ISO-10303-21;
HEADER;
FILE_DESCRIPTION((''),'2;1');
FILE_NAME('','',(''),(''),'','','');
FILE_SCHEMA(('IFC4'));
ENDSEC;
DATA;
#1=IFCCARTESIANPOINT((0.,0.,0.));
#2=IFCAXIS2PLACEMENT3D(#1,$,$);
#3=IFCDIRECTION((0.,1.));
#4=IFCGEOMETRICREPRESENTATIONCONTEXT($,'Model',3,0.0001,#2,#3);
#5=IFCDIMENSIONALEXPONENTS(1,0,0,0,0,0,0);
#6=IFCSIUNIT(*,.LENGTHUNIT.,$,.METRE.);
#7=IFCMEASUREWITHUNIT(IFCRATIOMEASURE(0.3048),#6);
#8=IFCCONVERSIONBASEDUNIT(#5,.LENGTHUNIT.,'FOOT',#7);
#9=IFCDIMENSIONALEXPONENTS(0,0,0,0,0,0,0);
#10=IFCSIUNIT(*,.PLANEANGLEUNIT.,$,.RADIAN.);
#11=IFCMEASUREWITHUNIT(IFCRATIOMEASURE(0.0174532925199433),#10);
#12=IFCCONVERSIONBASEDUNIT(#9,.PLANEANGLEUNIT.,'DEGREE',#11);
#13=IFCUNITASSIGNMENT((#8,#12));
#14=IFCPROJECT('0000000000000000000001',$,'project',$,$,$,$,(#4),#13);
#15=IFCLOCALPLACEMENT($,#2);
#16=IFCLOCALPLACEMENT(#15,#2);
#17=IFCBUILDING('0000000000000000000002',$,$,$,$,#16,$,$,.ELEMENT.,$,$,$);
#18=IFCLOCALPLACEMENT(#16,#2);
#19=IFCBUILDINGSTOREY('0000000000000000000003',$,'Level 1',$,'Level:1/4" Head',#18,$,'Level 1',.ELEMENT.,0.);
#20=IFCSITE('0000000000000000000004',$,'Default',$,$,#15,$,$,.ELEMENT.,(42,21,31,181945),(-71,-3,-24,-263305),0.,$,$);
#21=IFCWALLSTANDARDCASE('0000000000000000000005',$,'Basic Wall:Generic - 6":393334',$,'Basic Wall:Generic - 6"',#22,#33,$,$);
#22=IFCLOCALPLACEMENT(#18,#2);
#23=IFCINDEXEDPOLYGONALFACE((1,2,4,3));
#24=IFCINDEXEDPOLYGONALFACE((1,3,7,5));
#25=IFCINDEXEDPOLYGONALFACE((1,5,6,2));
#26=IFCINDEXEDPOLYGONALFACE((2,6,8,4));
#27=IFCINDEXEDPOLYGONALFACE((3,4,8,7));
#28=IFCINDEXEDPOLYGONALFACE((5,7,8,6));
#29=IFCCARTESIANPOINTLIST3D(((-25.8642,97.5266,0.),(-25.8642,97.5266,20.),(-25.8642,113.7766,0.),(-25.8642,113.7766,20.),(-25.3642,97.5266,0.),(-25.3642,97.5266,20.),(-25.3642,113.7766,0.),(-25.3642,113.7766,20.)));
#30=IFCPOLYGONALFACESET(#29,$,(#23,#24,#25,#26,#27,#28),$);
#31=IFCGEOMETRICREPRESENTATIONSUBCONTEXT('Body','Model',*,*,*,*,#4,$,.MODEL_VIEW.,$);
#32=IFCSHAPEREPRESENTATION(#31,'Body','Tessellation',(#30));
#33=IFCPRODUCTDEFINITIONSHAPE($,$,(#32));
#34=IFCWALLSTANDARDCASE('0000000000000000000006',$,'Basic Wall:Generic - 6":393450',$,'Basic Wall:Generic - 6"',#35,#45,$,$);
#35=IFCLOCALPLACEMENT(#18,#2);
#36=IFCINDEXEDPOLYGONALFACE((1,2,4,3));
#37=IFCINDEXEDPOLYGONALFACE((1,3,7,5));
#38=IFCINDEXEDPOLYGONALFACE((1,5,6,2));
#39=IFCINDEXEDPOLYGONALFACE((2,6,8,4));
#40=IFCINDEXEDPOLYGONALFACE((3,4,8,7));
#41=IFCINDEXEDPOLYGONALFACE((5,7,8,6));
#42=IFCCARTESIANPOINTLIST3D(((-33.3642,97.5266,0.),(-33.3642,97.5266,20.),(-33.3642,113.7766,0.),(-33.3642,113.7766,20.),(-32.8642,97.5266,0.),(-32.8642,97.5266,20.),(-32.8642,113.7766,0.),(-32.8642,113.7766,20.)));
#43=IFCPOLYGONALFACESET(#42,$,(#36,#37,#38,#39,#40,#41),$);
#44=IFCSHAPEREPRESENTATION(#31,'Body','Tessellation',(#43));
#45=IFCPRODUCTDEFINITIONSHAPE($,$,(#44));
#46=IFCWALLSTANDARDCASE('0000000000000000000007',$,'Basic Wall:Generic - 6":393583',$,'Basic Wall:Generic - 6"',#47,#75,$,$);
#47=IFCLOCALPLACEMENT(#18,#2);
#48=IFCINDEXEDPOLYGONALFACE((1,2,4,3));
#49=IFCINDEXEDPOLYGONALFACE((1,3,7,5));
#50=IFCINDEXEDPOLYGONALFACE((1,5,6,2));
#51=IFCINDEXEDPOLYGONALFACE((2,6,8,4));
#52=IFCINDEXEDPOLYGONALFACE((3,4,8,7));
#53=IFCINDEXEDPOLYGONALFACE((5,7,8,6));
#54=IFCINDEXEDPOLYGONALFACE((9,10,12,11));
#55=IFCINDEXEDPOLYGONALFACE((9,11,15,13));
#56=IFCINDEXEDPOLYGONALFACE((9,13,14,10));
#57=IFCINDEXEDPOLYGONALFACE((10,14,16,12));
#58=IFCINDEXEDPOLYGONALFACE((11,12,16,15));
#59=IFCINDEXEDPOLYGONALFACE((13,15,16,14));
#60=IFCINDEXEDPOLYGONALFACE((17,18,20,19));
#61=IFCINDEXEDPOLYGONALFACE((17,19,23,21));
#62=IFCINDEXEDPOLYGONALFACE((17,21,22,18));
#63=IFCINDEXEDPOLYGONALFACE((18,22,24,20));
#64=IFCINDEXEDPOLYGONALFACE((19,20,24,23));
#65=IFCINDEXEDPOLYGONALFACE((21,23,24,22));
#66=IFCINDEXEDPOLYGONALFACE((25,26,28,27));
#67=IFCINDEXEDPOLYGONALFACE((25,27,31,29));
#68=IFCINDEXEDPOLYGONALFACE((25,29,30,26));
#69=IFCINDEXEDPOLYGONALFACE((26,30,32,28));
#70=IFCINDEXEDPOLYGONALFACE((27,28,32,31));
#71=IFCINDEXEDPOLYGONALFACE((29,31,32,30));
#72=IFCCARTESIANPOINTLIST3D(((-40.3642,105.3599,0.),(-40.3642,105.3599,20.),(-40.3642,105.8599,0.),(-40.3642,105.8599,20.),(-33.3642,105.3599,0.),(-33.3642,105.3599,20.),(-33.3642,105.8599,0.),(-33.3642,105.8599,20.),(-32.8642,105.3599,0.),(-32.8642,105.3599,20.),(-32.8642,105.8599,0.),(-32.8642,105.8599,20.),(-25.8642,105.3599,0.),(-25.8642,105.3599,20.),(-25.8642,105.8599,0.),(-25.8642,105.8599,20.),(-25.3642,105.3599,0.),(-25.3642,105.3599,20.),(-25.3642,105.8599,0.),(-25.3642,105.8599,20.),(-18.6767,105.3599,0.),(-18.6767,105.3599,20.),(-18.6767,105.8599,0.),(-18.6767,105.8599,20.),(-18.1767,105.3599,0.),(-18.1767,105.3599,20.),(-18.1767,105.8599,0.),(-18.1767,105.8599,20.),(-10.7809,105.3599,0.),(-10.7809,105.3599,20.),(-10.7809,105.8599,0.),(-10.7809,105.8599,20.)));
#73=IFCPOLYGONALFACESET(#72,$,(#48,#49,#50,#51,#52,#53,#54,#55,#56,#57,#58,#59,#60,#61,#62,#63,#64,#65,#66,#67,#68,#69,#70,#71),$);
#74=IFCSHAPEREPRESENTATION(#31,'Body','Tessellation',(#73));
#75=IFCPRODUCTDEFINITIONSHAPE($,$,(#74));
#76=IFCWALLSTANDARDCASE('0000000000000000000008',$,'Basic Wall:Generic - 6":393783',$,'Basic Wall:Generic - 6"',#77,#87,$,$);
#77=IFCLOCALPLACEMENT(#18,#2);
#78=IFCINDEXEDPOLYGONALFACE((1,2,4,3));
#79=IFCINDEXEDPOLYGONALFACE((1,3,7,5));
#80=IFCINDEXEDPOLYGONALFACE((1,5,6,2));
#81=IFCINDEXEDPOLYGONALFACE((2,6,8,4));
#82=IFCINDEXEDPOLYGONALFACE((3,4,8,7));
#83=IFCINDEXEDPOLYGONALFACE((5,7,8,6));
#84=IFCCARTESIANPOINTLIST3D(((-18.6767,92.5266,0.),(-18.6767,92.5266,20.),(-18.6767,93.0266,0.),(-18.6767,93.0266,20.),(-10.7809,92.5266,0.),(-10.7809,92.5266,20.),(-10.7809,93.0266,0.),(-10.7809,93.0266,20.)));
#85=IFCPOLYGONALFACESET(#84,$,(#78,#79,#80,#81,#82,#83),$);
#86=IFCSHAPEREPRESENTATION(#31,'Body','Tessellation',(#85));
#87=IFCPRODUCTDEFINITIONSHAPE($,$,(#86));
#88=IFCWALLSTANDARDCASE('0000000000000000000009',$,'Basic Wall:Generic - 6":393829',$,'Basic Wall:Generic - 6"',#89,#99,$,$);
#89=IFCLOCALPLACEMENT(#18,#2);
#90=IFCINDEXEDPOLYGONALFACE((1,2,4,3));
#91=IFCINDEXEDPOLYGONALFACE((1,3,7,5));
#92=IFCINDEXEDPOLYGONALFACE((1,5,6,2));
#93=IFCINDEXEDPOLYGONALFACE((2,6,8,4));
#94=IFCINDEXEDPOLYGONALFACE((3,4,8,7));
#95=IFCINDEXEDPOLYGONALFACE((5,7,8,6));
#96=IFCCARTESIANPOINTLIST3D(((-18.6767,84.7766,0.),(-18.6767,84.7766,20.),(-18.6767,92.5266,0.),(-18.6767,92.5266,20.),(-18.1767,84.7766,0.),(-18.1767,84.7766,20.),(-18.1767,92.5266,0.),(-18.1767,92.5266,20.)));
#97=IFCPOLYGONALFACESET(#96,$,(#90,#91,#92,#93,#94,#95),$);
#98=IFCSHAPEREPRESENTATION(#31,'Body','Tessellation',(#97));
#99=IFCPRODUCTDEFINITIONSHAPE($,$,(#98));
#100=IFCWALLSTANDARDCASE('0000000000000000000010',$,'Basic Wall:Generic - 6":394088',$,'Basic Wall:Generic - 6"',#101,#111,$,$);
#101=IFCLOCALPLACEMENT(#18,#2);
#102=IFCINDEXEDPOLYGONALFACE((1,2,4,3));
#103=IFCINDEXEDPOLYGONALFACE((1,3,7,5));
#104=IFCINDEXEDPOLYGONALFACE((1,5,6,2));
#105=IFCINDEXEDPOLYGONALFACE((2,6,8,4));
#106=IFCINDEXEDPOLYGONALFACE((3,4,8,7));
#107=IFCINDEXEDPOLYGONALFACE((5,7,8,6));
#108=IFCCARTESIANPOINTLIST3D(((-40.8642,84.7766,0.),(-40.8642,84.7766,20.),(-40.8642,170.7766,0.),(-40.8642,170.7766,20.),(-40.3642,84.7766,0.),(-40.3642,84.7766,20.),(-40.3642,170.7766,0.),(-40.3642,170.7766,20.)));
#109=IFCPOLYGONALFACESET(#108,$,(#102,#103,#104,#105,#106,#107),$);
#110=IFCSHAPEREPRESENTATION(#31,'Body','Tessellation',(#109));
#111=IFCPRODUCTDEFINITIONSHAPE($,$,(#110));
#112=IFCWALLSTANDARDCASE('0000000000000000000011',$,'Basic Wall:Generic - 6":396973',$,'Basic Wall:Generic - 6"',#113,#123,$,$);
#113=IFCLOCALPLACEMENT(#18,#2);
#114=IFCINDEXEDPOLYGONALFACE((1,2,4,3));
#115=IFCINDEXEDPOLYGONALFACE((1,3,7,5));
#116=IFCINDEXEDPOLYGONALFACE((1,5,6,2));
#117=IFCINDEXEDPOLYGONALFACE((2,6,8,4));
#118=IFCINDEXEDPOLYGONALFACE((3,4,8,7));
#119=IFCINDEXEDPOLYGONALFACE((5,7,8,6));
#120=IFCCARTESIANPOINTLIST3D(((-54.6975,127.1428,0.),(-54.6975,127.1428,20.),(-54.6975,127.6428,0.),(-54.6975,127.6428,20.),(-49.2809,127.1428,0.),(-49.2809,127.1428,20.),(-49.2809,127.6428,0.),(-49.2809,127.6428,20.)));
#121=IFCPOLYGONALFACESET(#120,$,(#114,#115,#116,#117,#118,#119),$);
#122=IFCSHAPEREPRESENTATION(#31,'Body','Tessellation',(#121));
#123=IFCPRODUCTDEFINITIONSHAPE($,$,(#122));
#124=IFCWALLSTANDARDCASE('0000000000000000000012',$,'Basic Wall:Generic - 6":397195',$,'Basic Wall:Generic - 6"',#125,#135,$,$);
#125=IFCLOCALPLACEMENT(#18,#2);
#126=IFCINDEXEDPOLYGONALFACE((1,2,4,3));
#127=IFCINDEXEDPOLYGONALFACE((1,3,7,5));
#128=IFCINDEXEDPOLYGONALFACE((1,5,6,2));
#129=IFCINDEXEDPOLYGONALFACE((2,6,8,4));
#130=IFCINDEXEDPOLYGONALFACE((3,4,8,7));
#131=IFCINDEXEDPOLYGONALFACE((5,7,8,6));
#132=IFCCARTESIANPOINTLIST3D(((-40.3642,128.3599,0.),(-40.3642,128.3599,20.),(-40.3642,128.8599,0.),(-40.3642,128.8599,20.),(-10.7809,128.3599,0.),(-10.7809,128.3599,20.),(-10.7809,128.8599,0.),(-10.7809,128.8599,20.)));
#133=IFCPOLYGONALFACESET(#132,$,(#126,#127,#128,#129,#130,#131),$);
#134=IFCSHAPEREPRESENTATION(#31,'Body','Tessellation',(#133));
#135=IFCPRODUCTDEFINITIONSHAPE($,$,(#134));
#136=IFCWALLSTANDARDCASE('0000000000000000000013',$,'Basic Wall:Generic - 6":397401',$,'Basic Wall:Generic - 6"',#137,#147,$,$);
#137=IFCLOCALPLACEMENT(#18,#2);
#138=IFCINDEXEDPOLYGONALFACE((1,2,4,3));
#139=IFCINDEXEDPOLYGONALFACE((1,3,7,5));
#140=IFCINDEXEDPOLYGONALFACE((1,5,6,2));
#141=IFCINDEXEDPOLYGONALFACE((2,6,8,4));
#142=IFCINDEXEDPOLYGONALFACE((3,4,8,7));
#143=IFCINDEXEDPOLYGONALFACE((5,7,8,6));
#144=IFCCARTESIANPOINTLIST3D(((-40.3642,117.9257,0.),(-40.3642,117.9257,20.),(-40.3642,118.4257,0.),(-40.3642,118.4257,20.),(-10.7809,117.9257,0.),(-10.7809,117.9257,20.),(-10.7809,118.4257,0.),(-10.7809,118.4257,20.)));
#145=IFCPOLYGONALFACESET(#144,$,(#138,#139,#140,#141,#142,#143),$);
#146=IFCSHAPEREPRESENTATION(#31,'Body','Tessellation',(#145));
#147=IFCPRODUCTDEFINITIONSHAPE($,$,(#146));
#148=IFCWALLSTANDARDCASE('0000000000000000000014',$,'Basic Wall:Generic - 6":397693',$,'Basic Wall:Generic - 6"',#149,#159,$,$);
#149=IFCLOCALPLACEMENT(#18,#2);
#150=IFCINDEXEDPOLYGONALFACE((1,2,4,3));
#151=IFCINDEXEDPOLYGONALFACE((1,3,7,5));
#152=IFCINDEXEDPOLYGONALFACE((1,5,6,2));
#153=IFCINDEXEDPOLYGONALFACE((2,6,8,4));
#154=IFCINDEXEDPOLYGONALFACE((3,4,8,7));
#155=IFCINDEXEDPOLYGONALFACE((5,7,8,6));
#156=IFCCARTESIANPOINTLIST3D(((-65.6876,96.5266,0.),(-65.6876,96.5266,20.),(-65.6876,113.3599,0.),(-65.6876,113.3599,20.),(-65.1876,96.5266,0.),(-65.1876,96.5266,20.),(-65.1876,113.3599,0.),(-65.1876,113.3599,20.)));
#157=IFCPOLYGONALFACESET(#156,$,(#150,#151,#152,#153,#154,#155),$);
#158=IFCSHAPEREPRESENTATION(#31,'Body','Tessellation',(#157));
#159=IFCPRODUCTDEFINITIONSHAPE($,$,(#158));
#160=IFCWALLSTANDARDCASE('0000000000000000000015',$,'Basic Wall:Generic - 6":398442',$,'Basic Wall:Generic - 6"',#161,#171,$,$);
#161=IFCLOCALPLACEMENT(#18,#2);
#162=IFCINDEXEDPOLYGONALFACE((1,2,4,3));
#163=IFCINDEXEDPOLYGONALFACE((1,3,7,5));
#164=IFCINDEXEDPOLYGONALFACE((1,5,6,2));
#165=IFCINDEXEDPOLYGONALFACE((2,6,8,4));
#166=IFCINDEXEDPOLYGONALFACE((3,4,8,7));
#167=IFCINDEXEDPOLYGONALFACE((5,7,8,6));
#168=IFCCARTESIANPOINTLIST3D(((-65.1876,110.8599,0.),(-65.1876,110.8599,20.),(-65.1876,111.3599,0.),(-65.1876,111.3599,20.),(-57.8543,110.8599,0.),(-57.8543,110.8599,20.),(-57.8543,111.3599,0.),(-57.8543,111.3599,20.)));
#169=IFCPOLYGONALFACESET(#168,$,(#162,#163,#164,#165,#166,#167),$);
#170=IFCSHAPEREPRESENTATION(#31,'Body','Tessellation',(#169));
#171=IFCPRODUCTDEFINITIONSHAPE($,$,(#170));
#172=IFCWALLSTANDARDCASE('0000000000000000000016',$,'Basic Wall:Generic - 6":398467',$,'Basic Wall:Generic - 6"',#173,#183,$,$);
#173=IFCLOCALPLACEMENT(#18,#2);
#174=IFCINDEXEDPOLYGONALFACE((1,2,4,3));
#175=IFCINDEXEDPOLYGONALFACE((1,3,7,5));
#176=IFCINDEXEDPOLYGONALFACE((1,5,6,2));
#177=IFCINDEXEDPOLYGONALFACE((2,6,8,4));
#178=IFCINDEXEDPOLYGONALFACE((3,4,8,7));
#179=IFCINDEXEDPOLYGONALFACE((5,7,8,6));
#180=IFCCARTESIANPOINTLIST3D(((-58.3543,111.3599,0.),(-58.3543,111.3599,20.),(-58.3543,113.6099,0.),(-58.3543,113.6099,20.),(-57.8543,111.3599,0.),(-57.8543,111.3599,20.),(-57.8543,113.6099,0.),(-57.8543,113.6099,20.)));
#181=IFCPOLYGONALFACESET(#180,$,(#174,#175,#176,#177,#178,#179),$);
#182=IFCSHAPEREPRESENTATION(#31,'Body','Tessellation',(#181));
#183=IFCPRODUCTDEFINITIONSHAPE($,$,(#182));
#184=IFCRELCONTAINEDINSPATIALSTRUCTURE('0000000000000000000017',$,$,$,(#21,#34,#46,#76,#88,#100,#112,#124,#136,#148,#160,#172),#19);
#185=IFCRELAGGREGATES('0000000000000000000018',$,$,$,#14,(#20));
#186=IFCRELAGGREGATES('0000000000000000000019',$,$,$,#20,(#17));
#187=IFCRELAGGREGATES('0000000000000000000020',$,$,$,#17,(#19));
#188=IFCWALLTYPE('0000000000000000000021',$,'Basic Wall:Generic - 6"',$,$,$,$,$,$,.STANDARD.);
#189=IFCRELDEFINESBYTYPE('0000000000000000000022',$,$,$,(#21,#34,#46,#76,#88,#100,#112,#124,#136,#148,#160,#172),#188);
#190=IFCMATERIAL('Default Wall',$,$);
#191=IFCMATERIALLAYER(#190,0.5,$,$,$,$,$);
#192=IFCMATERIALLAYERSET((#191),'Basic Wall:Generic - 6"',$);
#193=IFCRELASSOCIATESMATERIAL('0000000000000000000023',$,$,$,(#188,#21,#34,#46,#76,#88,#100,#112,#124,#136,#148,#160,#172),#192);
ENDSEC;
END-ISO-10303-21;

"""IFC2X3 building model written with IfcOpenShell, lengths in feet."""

from ifc_helpers import new_model, entity, si_unit, converted_unit, direction, frame, frame_2d, origin, origin_2d_with_axis, place, context, subcontext, project, spatial, rectangle, extrude, material, layer, layer_set, layer_usage, type_object, element, save


model = new_model("IFC2X3")

# Units and contexts
model_context = context("Model", 3, precision=0.0001, world=origin(), true_north=direction((0.0, 1.0)))
body_context = subcontext(model_context, "Body", "Model", "MODEL_VIEW")
ifc_project = project(units=[converted_unit("LENGTHUNIT", "FOOT", entity("IfcRatioMeasure", 0.3048), si_unit("LENGTHUNIT", "METRE"), dimensions=[1, 0, 0, 0, 0, 0, 0]), converted_unit("PLANEANGLEUNIT", "DEGREE", entity("IfcRatioMeasure", 0.0174532925199433), si_unit("PLANEANGLEUNIT", "RADIAN"), dimensions=[0, 0, 0, 0, 0, 0, 0])], contexts=[model_context])

# Site, building, storey
site_placement = place(None, origin())
site = spatial("IfcSite", under=ifc_project, at=site_placement, Name="Default", CompositionType="ELEMENT", RefLatitude=(42, 21, 31, 181945), RefLongitude=(-71, -3, -24, -263305), RefElevation=0.0)
building_placement = place(site_placement, origin())
building = spatial("IfcBuilding", under=site, at=building_placement, CompositionType="ELEMENT")
storey_placement = place(building_placement, origin())
storey = spatial("IfcBuildingStorey", under=building, at=storey_placement, Name="Level 1", ObjectType="Level:1/4\" Head", LongName="Level 1", CompositionType="ELEMENT", Elevation=0.0)

# Shared definitions
ifc_material = material(Name="Default Wall")
ifc_layer = layer(ifc_material, 0.5)
ifc_layer_set = layer_set([ifc_layer], Name="Basic Wall:Generic - 6\"")
wall_type = type_object("IfcWallType", Name="Basic Wall:Generic - 6\"", PredefinedType="STANDARD", material=ifc_layer_set)

# Walls
ifc_layer_usage_1 = layer_usage(ifc_layer_set, "AXIS2", "NEGATIVE", 0.25)
wall_1_placement = place(storey_placement, frame((-25.6142, 97.5266, 0.0), z_axis=(0.0, 0.0, 1.0), x_axis=(0.0, 1.0, 0.0)))
element("IfcWallStandardCase", 1, at=wall_1_placement, inside=storey, type_object=wall_type, material=ifc_layer_usage_1, Name="Basic Wall:Generic - 6\":393334", ObjectType="Basic Wall:Generic - 6\"", context=body_context, shape_type="SweptSolid", body=[
    extrude(rectangle(XDim=16.25, YDim=0.5, at=frame_2d((8.125, 0.0), x_axis=(-1.0, 0.0))), origin(), (0.0, 0.0, 1.0), 20.0),
])
ifc_layer_usage_2 = layer_usage(ifc_layer_set, "AXIS2", "NEGATIVE", 0.25)
wall_2_placement = place(storey_placement, frame((-33.1142, 113.7766, 0.0), z_axis=(0.0, 0.0, 1.0), x_axis=(0.0, -1.0, 0.0)))
element("IfcWallStandardCase", 2, at=wall_2_placement, inside=storey, type_object=wall_type, material=ifc_layer_usage_2, Name="Basic Wall:Generic - 6\":393450", ObjectType="Basic Wall:Generic - 6\"", context=body_context, shape_type="SweptSolid", body=[
    extrude(rectangle(XDim=16.25, YDim=0.5, at=frame_2d((8.125, 0.0), x_axis=(-1.0, 0.0))), origin(), (0.0, 0.0, 1.0), 20.0),
])

# Wall, openings
ifc_layer_usage_3 = layer_usage(ifc_layer_set, "AXIS2", "NEGATIVE", 0.25)
wall_3_placement = place(storey_placement, frame((-10.7809, 105.6099, 0.0), z_axis=(0.0, 0.0, 1.0), x_axis=(-1.0, 0.0, 0.0)))
wall_3 = element("IfcWallStandardCase", 3, at=wall_3_placement, inside=storey, type_object=wall_type, material=ifc_layer_usage_3, Name="Basic Wall:Generic - 6\":393583", ObjectType="Basic Wall:Generic - 6\"", context=body_context, shape_type="SweptSolid", body=[
    extrude(rectangle(XDim=29.5833, YDim=0.5, at=frame_2d((14.7917, 0.0), x_axis=(-1.0, 0.0))), origin(), (0.0, 0.0, 1.0), 20.0),
])
opening_1_placement = place(storey_placement, frame((-10.7809, 105.6099, 0.0), z_axis=(0.0, 0.0, 1.0), x_axis=(-1.0, 0.0, 0.0)))
element("IfcOpeningElement", 4, at=opening_1_placement, cuts=wall_3, ObjectType="Opening", context=body_context, shape_type="SweptSolid", body=[
    extrude(rectangle(XDim=20.0, YDim=0.5, at=origin_2d_with_axis()), frame((22.5833, 0.0, 10.0), z_axis=(-1.0, 0.0, 0.0), x_axis=(0.0, 0.0, 1.0)), (0.0, 0.0, 1.0), 0.5),
])
opening_2_placement = place(storey_placement, frame((-10.7809, 105.6099, 0.0), z_axis=(0.0, 0.0, 1.0), x_axis=(-1.0, 0.0, 0.0)))
element("IfcOpeningElement", 5, at=opening_2_placement, cuts=wall_3, ObjectType="Opening", context=body_context, shape_type="SweptSolid", body=[
    extrude(rectangle(XDim=20.0, YDim=0.5, at=origin_2d_with_axis()), frame((15.0833, 0.0, 10.0), z_axis=(-1.0, 0.0, 0.0), x_axis=(0.0, 0.0, 1.0)), (0.0, 0.0, 1.0), 0.5),
])
opening_3_placement = place(storey_placement, frame((-10.7809, 105.6099, 0.0), z_axis=(0.0, 0.0, 1.0), x_axis=(-1.0, 0.0, 0.0)))
element("IfcOpeningElement", 6, at=opening_3_placement, cuts=wall_3, ObjectType="Opening", context=body_context, shape_type="SweptSolid", body=[
    extrude(rectangle(XDim=20.0, YDim=0.5, at=origin_2d_with_axis()), frame((7.8958, 0.0, 10.0), z_axis=(-1.0, 0.0, 0.0), x_axis=(0.0, 0.0, 1.0)), (0.0, 0.0, 1.0), 0.5),
])

# Walls
ifc_layer_usage_4 = layer_usage(ifc_layer_set, "AXIS2", "NEGATIVE", 0.25)
wall_4_placement = place(storey_placement, frame((-10.7809, 92.7766, 0.0), z_axis=(0.0, 0.0, 1.0), x_axis=(-1.0, 0.0, 0.0)))
element("IfcWallStandardCase", 7, at=wall_4_placement, inside=storey, type_object=wall_type, material=ifc_layer_usage_4, Name="Basic Wall:Generic - 6\":393783", ObjectType="Basic Wall:Generic - 6\"", context=body_context, shape_type="SweptSolid", body=[
    extrude(rectangle(XDim=7.8958, YDim=0.5, at=frame_2d((3.9479, 0.0), x_axis=(-1.0, 0.0))), origin(), (0.0, 0.0, 1.0), 20.0),
])
ifc_layer_usage_5 = layer_usage(ifc_layer_set, "AXIS2", "NEGATIVE", 0.25)
wall_5_placement = place(storey_placement, frame((-18.4267, 92.5266, 0.0), z_axis=(0.0, 0.0, 1.0), x_axis=(0.0, -1.0, 0.0)))
element("IfcWallStandardCase", 8, at=wall_5_placement, inside=storey, type_object=wall_type, material=ifc_layer_usage_5, Name="Basic Wall:Generic - 6\":393829", ObjectType="Basic Wall:Generic - 6\"", context=body_context, shape_type="SweptSolid", body=[
    extrude(rectangle(XDim=7.75, YDim=0.5, at=frame_2d((3.875, 0.0), x_axis=(-1.0, 0.0))), origin(), (0.0, 0.0, 1.0), 20.0),
])
ifc_layer_usage_6 = layer_usage(ifc_layer_set, "AXIS2", "NEGATIVE", 0.25)
wall_6_placement = place(storey_placement, frame((-40.6142, 84.7766, 0.0), z_axis=(0.0, 0.0, 1.0), x_axis=(0.0, 1.0, 0.0)))
element("IfcWallStandardCase", 9, at=wall_6_placement, inside=storey, type_object=wall_type, material=ifc_layer_usage_6, Name="Basic Wall:Generic - 6\":394088", ObjectType="Basic Wall:Generic - 6\"", context=body_context, shape_type="SweptSolid", body=[
    extrude(rectangle(XDim=86.0, YDim=0.5, at=frame_2d((43.0, 0.0), x_axis=(-1.0, 0.0))), origin(), (0.0, 0.0, 1.0), 20.0),
])
ifc_layer_usage_7 = layer_usage(ifc_layer_set, "AXIS2", "NEGATIVE", 0.25)
wall_7_placement = place(storey_placement, frame((-49.2809, 127.3928, 0.0), z_axis=(0.0, 0.0, 1.0), x_axis=(-1.0, 0.0, 0.0)))
element("IfcWallStandardCase", 10, at=wall_7_placement, inside=storey, type_object=wall_type, material=ifc_layer_usage_7, Name="Basic Wall:Generic - 6\":396973", ObjectType="Basic Wall:Generic - 6\"", context=body_context, shape_type="SweptSolid", body=[
    extrude(rectangle(XDim=5.4167, YDim=0.5, at=frame_2d((2.7083, 0.0), x_axis=(-1.0, 0.0))), origin(), (0.0, 0.0, 1.0), 20.0),
])
ifc_layer_usage_8 = layer_usage(ifc_layer_set, "AXIS2", "NEGATIVE", 0.25)
wall_8_placement = place(storey_placement, frame((-40.3642, 128.6099, 0.0)))
element("IfcWallStandardCase", 11, at=wall_8_placement, inside=storey, type_object=wall_type, material=ifc_layer_usage_8, Name="Basic Wall:Generic - 6\":397195", ObjectType="Basic Wall:Generic - 6\"", context=body_context, shape_type="SweptSolid", body=[
    extrude(rectangle(XDim=29.5833, YDim=0.5, at=frame_2d((14.7917, 0.0), x_axis=(-1.0, 0.0))), origin(), (0.0, 0.0, 1.0), 20.0),
])
ifc_layer_usage_9 = layer_usage(ifc_layer_set, "AXIS2", "NEGATIVE", 0.25)
wall_9_placement = place(storey_placement, frame((-40.3642, 118.1757, 0.0)))
element("IfcWallStandardCase", 12, at=wall_9_placement, inside=storey, type_object=wall_type, material=ifc_layer_usage_9, Name="Basic Wall:Generic - 6\":397401", ObjectType="Basic Wall:Generic - 6\"", context=body_context, shape_type="SweptSolid", body=[
    extrude(rectangle(XDim=29.5833, YDim=0.5, at=frame_2d((14.7917, 0.0), x_axis=(-1.0, 0.0))), origin(), (0.0, 0.0, 1.0), 20.0),
])
ifc_layer_usage_10 = layer_usage(ifc_layer_set, "AXIS2", "NEGATIVE", 0.25)
wall_10_placement = place(storey_placement, frame((-65.4376, 113.3599, 0.0), z_axis=(0.0, 0.0, 1.0), x_axis=(0.0, -1.0, 0.0)))
element("IfcWallStandardCase", 13, at=wall_10_placement, inside=storey, type_object=wall_type, material=ifc_layer_usage_10, Name="Basic Wall:Generic - 6\":397693", ObjectType="Basic Wall:Generic - 6\"", context=body_context, shape_type="SweptSolid", body=[
    extrude(rectangle(XDim=16.8333, YDim=0.5, at=frame_2d((8.4167, 0.0), x_axis=(-1.0, 0.0))), origin(), (0.0, 0.0, 1.0), 20.0),
])
ifc_layer_usage_11 = layer_usage(ifc_layer_set, "AXIS2", "NEGATIVE", 0.25)
wall_11_placement = place(storey_placement, frame((-65.1876, 111.1099, 0.0)))
element("IfcWallStandardCase", 14, at=wall_11_placement, inside=storey, type_object=wall_type, material=ifc_layer_usage_11, Name="Basic Wall:Generic - 6\":398442", ObjectType="Basic Wall:Generic - 6\"", context=body_context, shape_type="SweptSolid", body=[
    extrude(rectangle(XDim=7.3333, YDim=0.5, at=frame_2d((3.6667, 0.0), x_axis=(-1.0, 0.0))), origin(), (0.0, 0.0, 1.0), 20.0),
])
ifc_layer_usage_12 = layer_usage(ifc_layer_set, "AXIS2", "NEGATIVE", 0.25)
wall_12_placement = place(storey_placement, frame((-58.1043, 111.3599, 0.0), z_axis=(0.0, 0.0, 1.0), x_axis=(0.0, 1.0, 0.0)))
element("IfcWallStandardCase", 15, at=wall_12_placement, inside=storey, type_object=wall_type, material=ifc_layer_usage_12, Name="Basic Wall:Generic - 6\":398467", ObjectType="Basic Wall:Generic - 6\"", context=body_context, shape_type="SweptSolid", body=[
    extrude(rectangle(XDim=2.25, YDim=0.5, at=frame_2d((1.125, 0.0), x_axis=(-1.0, 0.0))), origin(), (0.0, 0.0, 1.0), 20.0),
])

save(model, "model.ifc")
